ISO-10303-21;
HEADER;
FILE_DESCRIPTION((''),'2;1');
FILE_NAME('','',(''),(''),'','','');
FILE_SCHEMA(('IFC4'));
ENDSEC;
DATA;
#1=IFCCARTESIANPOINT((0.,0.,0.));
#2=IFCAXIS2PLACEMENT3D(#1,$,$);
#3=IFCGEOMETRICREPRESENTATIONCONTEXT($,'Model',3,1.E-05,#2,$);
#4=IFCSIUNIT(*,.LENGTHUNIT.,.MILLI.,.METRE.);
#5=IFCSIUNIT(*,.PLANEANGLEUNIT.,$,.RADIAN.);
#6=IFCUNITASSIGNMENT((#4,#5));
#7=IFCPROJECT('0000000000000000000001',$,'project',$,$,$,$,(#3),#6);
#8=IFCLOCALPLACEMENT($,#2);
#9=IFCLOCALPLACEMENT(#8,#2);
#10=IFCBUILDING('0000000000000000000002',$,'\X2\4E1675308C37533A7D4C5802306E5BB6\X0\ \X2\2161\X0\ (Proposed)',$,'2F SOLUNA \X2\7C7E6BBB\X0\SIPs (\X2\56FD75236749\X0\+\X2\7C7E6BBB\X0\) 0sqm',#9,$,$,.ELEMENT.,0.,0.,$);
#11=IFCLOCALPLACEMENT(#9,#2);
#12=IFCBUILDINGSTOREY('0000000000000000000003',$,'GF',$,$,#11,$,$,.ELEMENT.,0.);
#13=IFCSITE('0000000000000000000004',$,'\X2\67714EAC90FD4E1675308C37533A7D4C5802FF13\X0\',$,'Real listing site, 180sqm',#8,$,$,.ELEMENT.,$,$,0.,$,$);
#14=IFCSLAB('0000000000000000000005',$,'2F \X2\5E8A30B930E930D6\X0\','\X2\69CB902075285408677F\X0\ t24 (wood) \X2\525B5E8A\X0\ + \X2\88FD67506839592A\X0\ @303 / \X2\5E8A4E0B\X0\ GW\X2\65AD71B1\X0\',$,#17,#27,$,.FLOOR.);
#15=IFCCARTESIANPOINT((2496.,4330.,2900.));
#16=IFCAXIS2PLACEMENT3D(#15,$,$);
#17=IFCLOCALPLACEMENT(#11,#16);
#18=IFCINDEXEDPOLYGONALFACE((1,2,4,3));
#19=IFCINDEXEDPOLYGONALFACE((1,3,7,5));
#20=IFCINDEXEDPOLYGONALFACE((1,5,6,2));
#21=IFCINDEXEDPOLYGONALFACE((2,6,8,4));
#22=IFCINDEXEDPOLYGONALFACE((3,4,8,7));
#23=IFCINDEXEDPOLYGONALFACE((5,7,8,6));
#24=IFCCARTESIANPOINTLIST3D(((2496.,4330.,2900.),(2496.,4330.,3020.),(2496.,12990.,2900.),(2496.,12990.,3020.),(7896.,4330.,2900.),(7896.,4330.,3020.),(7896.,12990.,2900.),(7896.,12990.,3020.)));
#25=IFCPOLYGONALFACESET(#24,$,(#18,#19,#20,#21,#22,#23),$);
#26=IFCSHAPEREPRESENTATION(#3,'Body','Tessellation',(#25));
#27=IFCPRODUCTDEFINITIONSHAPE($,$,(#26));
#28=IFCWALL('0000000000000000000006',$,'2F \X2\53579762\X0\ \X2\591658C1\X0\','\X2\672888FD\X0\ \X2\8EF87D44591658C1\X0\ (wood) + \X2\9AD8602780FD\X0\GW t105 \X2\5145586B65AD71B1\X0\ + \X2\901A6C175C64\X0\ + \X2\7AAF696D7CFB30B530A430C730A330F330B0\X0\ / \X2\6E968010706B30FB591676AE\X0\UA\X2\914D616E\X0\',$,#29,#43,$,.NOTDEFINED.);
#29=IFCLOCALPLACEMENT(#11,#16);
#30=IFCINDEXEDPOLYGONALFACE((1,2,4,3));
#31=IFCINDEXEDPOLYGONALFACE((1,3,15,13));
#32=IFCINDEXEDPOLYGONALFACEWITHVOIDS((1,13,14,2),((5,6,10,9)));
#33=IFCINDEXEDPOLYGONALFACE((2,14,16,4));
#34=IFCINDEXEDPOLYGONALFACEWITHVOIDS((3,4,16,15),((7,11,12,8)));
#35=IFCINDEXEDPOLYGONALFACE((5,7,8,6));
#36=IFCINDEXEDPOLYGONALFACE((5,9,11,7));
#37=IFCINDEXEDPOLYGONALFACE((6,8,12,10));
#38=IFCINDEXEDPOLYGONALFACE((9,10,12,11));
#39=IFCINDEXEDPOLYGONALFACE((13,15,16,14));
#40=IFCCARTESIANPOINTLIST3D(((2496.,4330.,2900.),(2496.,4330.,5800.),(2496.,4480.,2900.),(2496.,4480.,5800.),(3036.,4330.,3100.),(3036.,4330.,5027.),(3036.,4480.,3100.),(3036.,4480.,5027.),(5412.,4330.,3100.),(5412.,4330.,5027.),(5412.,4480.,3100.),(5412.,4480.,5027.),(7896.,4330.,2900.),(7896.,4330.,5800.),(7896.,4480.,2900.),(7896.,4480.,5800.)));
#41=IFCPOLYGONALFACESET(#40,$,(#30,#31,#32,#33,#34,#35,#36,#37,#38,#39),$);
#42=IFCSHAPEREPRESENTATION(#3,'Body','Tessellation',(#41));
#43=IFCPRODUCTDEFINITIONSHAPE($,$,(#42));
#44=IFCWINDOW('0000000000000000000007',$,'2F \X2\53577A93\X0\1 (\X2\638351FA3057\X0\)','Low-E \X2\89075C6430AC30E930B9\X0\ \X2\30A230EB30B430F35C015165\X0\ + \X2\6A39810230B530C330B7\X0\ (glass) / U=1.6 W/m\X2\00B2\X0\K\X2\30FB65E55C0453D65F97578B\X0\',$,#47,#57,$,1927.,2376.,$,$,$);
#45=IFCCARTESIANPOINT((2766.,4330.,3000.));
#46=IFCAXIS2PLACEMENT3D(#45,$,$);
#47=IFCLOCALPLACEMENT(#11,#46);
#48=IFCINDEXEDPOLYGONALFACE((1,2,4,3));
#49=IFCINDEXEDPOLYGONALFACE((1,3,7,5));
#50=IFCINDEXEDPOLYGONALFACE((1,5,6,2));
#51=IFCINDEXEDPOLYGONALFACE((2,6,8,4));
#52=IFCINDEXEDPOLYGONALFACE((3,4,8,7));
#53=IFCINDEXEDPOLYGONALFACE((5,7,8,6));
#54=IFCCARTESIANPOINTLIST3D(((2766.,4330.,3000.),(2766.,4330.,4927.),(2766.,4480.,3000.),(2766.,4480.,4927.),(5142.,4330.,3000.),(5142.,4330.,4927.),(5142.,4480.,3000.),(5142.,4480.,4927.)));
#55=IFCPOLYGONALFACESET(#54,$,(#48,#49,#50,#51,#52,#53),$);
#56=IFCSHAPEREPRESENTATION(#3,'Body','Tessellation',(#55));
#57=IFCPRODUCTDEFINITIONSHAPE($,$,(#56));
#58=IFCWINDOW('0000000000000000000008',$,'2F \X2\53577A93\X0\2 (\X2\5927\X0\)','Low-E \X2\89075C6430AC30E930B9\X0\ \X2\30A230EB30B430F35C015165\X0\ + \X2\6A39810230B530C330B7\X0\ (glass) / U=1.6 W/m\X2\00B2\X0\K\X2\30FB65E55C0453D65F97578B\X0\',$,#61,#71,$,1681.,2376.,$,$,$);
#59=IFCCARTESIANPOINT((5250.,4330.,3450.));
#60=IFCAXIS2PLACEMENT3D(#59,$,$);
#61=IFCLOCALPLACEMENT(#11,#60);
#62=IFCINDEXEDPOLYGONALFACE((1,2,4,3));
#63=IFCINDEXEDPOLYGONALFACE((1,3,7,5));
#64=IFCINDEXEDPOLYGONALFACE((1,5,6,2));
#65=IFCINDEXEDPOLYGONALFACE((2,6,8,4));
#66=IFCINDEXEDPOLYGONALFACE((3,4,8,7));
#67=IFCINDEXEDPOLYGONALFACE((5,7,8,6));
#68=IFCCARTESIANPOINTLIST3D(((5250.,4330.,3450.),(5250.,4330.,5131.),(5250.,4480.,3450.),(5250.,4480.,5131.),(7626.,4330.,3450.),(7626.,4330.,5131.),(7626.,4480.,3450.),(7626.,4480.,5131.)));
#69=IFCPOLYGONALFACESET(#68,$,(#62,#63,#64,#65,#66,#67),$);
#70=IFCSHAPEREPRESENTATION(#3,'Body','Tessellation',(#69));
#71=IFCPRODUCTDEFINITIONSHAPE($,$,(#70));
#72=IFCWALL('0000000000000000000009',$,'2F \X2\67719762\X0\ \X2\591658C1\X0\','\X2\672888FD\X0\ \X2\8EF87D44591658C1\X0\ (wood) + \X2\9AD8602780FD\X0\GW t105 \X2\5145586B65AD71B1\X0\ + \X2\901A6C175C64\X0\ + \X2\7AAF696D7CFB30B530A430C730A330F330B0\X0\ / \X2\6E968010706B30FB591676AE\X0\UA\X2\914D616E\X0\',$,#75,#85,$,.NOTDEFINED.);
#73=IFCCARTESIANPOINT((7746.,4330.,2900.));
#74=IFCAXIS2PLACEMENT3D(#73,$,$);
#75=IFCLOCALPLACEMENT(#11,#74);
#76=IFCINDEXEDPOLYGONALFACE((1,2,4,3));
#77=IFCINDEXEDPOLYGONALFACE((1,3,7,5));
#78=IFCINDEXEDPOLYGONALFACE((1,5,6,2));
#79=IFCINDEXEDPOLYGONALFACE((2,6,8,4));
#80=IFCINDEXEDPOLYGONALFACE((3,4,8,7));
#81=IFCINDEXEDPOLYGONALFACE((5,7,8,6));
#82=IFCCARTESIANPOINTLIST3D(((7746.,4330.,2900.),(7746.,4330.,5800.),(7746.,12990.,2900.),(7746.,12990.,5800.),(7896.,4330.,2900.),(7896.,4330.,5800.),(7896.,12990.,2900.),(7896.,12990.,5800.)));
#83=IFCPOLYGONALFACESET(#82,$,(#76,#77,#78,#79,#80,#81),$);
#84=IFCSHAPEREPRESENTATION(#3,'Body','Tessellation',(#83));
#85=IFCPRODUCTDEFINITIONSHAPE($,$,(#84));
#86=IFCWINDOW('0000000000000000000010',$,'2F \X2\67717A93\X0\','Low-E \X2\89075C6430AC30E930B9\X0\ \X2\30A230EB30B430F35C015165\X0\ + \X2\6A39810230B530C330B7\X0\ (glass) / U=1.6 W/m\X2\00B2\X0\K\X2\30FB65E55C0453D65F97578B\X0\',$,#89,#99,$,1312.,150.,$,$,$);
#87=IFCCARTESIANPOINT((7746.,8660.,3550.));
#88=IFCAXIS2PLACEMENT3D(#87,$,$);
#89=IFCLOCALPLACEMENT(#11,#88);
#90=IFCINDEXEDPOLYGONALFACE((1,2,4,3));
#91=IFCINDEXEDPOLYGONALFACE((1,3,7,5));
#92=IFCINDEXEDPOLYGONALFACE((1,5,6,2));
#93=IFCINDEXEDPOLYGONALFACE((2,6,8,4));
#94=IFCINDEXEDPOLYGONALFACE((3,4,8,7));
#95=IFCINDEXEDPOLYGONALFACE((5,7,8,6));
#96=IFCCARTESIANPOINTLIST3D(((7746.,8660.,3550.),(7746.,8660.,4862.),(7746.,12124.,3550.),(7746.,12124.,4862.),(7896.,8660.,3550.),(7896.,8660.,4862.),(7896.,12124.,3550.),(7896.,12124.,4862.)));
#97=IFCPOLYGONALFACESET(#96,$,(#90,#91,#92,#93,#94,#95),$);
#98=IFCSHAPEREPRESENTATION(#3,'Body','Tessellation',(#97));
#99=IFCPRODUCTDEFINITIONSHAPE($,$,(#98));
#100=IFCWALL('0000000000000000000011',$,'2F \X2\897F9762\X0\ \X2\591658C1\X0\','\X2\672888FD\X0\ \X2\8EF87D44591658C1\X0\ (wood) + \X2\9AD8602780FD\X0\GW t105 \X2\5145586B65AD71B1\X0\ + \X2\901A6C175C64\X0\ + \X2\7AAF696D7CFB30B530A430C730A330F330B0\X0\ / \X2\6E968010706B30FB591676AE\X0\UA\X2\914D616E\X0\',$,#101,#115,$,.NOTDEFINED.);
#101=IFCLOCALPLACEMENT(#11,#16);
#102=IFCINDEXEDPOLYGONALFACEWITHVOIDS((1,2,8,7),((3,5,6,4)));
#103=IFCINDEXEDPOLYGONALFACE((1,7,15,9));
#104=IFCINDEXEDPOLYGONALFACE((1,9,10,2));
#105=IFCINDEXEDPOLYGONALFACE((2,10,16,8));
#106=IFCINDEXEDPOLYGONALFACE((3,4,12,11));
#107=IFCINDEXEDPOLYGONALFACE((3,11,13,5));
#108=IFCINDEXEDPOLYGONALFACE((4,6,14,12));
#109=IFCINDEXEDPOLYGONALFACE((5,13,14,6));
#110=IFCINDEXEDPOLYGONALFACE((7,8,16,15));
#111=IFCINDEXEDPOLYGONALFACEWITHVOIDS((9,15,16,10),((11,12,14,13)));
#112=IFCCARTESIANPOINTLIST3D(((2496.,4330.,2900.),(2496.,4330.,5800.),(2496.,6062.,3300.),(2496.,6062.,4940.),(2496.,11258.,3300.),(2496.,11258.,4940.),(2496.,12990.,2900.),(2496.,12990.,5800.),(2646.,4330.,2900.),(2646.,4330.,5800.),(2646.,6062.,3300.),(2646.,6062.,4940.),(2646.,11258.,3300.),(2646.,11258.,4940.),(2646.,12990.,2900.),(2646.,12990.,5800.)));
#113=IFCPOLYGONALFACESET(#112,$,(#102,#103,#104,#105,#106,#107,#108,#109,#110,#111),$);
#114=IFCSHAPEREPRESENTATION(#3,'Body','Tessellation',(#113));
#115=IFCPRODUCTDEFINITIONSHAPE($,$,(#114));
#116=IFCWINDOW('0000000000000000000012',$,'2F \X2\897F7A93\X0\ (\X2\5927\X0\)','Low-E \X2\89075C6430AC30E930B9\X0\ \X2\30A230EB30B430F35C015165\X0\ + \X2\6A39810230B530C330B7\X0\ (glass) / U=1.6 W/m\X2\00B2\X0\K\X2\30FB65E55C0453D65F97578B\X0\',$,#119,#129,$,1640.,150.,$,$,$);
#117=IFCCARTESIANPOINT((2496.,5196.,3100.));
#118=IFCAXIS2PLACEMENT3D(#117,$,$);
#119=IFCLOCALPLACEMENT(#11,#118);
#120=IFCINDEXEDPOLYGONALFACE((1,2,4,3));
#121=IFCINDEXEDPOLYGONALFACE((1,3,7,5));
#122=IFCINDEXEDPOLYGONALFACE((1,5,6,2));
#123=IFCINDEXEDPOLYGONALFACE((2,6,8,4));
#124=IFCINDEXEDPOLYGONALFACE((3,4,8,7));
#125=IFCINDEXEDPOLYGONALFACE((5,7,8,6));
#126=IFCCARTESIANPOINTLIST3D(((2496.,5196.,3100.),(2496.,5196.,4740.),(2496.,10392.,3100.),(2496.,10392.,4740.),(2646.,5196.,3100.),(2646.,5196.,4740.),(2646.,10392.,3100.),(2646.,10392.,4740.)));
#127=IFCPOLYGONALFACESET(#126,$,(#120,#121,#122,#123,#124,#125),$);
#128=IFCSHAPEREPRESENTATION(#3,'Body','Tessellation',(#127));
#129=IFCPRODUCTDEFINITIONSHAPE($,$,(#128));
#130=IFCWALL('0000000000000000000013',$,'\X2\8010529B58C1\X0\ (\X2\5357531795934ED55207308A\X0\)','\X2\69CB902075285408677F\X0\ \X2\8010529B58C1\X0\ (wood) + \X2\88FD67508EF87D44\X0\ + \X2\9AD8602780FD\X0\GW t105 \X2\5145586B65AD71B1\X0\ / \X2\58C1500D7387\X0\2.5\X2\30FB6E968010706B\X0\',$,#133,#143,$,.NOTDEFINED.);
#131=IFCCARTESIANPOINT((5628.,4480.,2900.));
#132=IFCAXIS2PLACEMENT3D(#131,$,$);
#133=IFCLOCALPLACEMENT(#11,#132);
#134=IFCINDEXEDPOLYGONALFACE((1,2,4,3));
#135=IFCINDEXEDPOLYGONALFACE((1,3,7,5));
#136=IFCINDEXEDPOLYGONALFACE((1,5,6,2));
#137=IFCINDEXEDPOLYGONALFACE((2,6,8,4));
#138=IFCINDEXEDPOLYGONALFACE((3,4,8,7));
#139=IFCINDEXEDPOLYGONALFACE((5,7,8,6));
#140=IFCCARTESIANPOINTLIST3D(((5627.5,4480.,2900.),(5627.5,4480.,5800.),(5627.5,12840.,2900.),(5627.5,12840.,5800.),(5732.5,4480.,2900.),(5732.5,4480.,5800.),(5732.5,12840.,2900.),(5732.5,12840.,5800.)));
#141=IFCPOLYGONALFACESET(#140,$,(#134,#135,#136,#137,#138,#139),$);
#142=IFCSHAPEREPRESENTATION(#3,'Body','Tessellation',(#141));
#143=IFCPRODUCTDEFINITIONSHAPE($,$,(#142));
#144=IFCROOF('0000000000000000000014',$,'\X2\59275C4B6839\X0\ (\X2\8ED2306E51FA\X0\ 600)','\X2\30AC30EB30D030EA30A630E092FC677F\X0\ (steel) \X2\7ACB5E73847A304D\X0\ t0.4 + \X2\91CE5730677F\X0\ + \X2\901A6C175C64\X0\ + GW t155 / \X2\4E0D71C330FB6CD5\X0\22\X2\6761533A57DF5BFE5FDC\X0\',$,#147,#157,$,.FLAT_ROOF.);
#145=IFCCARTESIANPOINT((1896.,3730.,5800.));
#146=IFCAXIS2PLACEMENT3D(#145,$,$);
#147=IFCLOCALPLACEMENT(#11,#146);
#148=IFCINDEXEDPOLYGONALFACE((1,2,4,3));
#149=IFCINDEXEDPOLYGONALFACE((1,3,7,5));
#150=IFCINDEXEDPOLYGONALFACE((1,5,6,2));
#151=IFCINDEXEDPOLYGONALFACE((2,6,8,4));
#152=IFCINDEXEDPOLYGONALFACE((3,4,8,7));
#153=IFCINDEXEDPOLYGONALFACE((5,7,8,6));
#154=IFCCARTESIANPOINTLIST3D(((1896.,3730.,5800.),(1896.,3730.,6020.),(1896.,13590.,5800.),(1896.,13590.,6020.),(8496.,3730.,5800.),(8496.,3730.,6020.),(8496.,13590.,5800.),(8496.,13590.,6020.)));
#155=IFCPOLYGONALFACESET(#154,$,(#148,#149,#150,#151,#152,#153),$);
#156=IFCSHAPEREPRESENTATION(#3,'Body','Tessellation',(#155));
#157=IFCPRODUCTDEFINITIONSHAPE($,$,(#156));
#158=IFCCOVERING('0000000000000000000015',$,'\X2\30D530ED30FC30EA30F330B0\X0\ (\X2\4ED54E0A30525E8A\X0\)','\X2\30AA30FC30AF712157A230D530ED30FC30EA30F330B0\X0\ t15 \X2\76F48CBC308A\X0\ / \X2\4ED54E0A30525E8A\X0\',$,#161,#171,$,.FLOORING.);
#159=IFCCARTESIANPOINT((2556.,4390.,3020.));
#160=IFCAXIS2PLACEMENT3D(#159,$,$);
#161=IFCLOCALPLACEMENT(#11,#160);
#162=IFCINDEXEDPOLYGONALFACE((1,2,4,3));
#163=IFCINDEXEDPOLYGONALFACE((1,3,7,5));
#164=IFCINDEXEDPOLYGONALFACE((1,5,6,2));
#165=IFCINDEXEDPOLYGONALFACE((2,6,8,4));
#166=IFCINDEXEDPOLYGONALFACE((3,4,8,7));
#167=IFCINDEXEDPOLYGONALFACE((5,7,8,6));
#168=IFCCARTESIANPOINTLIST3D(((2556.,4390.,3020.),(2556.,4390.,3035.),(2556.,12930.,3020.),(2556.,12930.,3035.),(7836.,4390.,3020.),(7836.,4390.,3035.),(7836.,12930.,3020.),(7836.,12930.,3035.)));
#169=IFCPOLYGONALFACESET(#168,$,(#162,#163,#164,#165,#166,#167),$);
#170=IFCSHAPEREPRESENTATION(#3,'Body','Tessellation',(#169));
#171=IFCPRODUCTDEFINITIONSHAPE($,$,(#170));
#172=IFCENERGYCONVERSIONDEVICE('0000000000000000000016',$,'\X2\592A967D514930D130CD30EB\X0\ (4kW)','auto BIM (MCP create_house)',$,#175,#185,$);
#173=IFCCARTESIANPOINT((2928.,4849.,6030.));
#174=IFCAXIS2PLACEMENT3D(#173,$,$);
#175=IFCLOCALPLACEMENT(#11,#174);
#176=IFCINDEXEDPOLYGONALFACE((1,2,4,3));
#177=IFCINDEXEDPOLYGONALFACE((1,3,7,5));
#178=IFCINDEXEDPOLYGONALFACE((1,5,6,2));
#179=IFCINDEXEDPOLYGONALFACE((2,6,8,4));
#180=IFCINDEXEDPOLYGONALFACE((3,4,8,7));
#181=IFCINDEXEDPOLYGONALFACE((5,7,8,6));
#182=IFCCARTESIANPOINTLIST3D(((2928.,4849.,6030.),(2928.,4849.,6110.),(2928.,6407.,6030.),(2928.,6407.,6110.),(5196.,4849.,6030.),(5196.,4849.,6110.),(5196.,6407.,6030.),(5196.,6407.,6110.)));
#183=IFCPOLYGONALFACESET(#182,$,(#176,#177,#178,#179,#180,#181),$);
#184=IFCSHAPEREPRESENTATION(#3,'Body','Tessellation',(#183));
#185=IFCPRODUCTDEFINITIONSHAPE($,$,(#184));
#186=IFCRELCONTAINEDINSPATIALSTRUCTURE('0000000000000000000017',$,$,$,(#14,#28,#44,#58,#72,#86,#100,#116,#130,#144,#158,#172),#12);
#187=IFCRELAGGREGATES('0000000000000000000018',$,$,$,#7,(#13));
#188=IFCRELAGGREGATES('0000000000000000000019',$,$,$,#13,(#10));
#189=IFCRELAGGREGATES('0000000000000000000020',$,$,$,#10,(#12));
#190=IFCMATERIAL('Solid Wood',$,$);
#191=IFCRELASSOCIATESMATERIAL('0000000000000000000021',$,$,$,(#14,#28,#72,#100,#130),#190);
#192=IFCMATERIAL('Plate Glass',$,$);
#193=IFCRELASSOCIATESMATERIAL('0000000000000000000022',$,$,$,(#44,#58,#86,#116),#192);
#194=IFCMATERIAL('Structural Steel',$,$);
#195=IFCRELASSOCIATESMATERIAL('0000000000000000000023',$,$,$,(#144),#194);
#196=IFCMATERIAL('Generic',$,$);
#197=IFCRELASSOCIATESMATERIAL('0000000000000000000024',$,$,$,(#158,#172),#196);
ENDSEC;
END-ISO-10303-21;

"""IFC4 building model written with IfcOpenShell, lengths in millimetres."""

from ifc_helpers import new_model, si_unit, frame, frame_2d, origin, place, context, project, spatial, rectangle, extrude, material, element, fill, save


model = new_model("IFC4")

# Units and contexts
model_context = context("Model", 3, precision=1e-05, world=origin())
ifc_project = project(units=[si_unit("LENGTHUNIT", "METRE", prefix="MILLI"), si_unit("PLANEANGLEUNIT", "RADIAN")], contexts=[model_context])

# Site, building, storey
site_placement = place(None, origin())
site = spatial("IfcSite", under=ifc_project, at=site_placement, Name="東京都世田谷区経堂３", ObjectType="Real listing site, 180sqm", CompositionType="ELEMENT", RefElevation=0.0)
building_placement = place(site_placement, origin())
building = spatial("IfcBuilding", under=site, at=building_placement, Name="世田谷区経堂の家 Ⅱ (Proposed)", ObjectType="2F SOLUNA 籾殻SIPs (国産杉+籾殻) 0sqm", CompositionType="ELEMENT", ElevationOfRefHeight=0.0, ElevationOfTerrain=0.0)
storey_placement = place(building_placement, origin())
storey = spatial("IfcBuildingStorey", under=building, at=storey_placement, Name="GF", CompositionType="ELEMENT", Elevation=0.0)

# Slab
ifc_material_1 = material(Name="Solid Wood")
slab_placement = place(storey_placement, frame((2496.0, 4330.0, 2900.0)))
element("IfcSlab", 1, at=slab_placement, inside=storey, material=ifc_material_1, Name="2F 床スラブ", Description="構造用合板 t24 (wood) 剛床 + 製材根太 @303 / 床下 GW断熱", PredefinedType="FLOOR", context=model_context, shape_type="SweptSolid", body=[
    extrude(rectangle(XDim=5400.0, YDim=8660.0, at=frame_2d((2700.0, 4330.0))), frame((2496.0, 4330.0, 2900.0)), (0.0, 0.0, 1.0), 120.0),
])

# Wall, openings, windows
wall_1_placement = place(storey_placement, frame((2496.0, 4330.0, 2900.0)))
wall_1 = element("IfcWall", 2, at=wall_1_placement, inside=storey, material=ifc_material_1, Name="2F 南面 外壁", Description="木製 軸組外壁 (wood) + 高性能GW t105 充填断熱 + 通気層 + 窯業系サイディング / 準耐火・外皮UA配慮", PredefinedType="NOTDEFINED", context=model_context, shape_type="SweptSolid", body=[
    extrude(rectangle(XDim=5400.0, YDim=150.0, at=frame_2d((2700.0, 75.0))), frame((2496.0, 4330.0, 2900.0)), (0.0, 0.0, 1.0), 2900.0),
])
opening_1_placement = place(storey_placement, frame((2766.0, 4330.0, 3000.0)))
opening_1 = element("IfcOpeningElement", 3, at=opening_1_placement, cuts=wall_1, PredefinedType="NOTDEFINED", context=model_context, shape_type="SweptSolid", body=[
    extrude(rectangle(XDim=2376.0, YDim=150.0, at=frame_2d((1188.0, 75.0))), frame((2766.0, 4330.0, 3000.0)), (0.0, 0.0, 1.0), 1927.0),
])
opening_2_placement = place(storey_placement, frame((5250.0, 4330.0, 3450.0)))
opening_2 = element("IfcOpeningElement", 4, at=opening_2_placement, cuts=wall_1, PredefinedType="NOTDEFINED", context=model_context, shape_type="SweptSolid", body=[
    extrude(rectangle(XDim=2376.0, YDim=150.0, at=frame_2d((1188.0, 75.0))), frame((5250.0, 4330.0, 3450.0)), (0.0, 0.0, 1.0), 1681.0),
])
ifc_material_2 = material(Name="Plate Glass")
window_1_placement = place(storey_placement, frame((2766.0, 4330.0, 3000.0)))
window_1 = element("IfcWindow", 5, at=window_1_placement, inside=storey, material=ifc_material_2, Name="2F 南窓1 (掃出し)", Description="Low-E 複層ガラス アルゴン封入 + 樹脂サッシ (glass) / U=1.6 W/m²K・日射取得型", OverallHeight=1927.0, OverallWidth=2376.0, context=model_context, shape_type="SweptSolid", body=[
    extrude(rectangle(XDim=2376.0, YDim=150.0, at=frame_2d((1188.0, 75.0))), frame((2766.0, 4330.0, 3000.0)), (0.0, 0.0, 1.0), 1927.0),
])
fill(opening_1, window_1)
window_2_placement = place(storey_placement, frame((5250.0, 4330.0, 3450.0)))
window_2 = element("IfcWindow", 6, at=window_2_placement, inside=storey, material=ifc_material_2, Name="2F 南窓2 (大)", Description="Low-E 複層ガラス アルゴン封入 + 樹脂サッシ (glass) / U=1.6 W/m²K・日射取得型", OverallHeight=1681.0, OverallWidth=2376.0, context=model_context, shape_type="SweptSolid", body=[
    extrude(rectangle(XDim=2376.0, YDim=150.0, at=frame_2d((1188.0, 75.0))), frame((5250.0, 4330.0, 3450.0)), (0.0, 0.0, 1.0), 1681.0),
])
fill(opening_2, window_2)

# Walls, openings, windows
wall_2_placement = place(storey_placement, frame((7746.0, 4330.0, 2900.0)))
wall_2 = element("IfcWall", 7, at=wall_2_placement, inside=storey, material=ifc_material_1, Name="2F 東面 外壁", Description="木製 軸組外壁 (wood) + 高性能GW t105 充填断熱 + 通気層 + 窯業系サイディング / 準耐火・外皮UA配慮", PredefinedType="NOTDEFINED", context=model_context, shape_type="SweptSolid", body=[
    extrude(rectangle(XDim=150.0, YDim=8660.0, at=frame_2d((75.0, 4330.0))), frame((7746.0, 4330.0, 2900.0)), (0.0, 0.0, 1.0), 2900.0),
])
opening_3_placement = place(storey_placement, frame((7746.0, 8660.0, 3550.0)))
opening_3 = element("IfcOpeningElement", 8, at=opening_3_placement, cuts=wall_2, PredefinedType="NOTDEFINED", context=model_context, shape_type="SweptSolid", body=[
    extrude(rectangle(XDim=150.0, YDim=3464.0, at=frame_2d((75.0, 1732.0))), frame((7746.0, 8660.0, 3550.0)), (0.0, 0.0, 1.0), 1312.0),
])
window_3_placement = place(storey_placement, frame((7746.0, 8660.0, 3550.0)))
window_3 = element("IfcWindow", 9, at=window_3_placement, inside=storey, material=ifc_material_2, Name="2F 東窓", Description="Low-E 複層ガラス アルゴン封入 + 樹脂サッシ (glass) / U=1.6 W/m²K・日射取得型", OverallHeight=1312.0, OverallWidth=150.0, context=model_context, shape_type="SweptSolid", body=[
    extrude(rectangle(XDim=150.0, YDim=3464.0, at=frame_2d((75.0, 1732.0))), frame((7746.0, 8660.0, 3550.0)), (0.0, 0.0, 1.0), 1312.0),
])
fill(opening_3, window_3)
wall_3_placement = place(storey_placement, frame((2496.0, 4330.0, 2900.0)))
wall_3 = element("IfcWall", 10, at=wall_3_placement, inside=storey, material=ifc_material_1, Name="2F 西面 外壁", Description="木製 軸組外壁 (wood) + 高性能GW t105 充填断熱 + 通気層 + 窯業系サイディング / 準耐火・外皮UA配慮", PredefinedType="NOTDEFINED", context=model_context, shape_type="SweptSolid", body=[
    extrude(rectangle(XDim=150.0, YDim=8660.0, at=frame_2d((75.0, 4330.0))), frame((2496.0, 4330.0, 2900.0)), (0.0, 0.0, 1.0), 2900.0),
])
opening_4_placement = place(storey_placement, frame((2496.0, 5196.0, 3100.0)))
opening_4 = element("IfcOpeningElement", 11, at=opening_4_placement, cuts=wall_3, PredefinedType="NOTDEFINED", context=model_context, shape_type="SweptSolid", body=[
    extrude(rectangle(XDim=150.0, YDim=5196.0, at=frame_2d((75.0, 2598.0))), frame((2496.0, 5196.0, 3100.0)), (0.0, 0.0, 1.0), 1640.0),
])
window_4_placement = place(storey_placement, frame((2496.0, 5196.0, 3100.0)))
window_4 = element("IfcWindow", 12, at=window_4_placement, inside=storey, material=ifc_material_2, Name="2F 西窓 (大)", Description="Low-E 複層ガラス アルゴン封入 + 樹脂サッシ (glass) / U=1.6 W/m²K・日射取得型", OverallHeight=1640.0, OverallWidth=150.0, context=model_context, shape_type="SweptSolid", body=[
    extrude(rectangle(XDim=150.0, YDim=5196.0, at=frame_2d((75.0, 2598.0))), frame((2496.0, 5196.0, 3100.0)), (0.0, 0.0, 1.0), 1640.0),
])
fill(opening_4, window_4)

# Wall
wall_4_placement = place(storey_placement, frame((5628.0, 4480.0, 2900.0)))
element("IfcWall", 13, at=wall_4_placement, inside=storey, material=ifc_material_1, Name="耐力壁 (南北間仕切り)", Description="構造用合板 耐力壁 (wood) + 製材軸組 + 高性能GW t105 充填断熱 / 壁倍率2.5・準耐火", PredefinedType="NOTDEFINED", context=model_context, shape_type="SweptSolid", body=[
    extrude(rectangle(XDim=105.0, YDim=8360.0, at=frame_2d((52.0, 4180.0))), frame((5628.0, 4480.0, 2900.0)), (0.0, 0.0, 1.0), 2900.0),
])

# Roof
ifc_material_3 = material(Name="Structural Steel")
roof_placement = place(storey_placement, frame((1896.0, 3730.0, 5800.0)))
element("IfcRoof", 14, at=roof_placement, inside=storey, material=ifc_material_3, Name="大屋根 (軒の出 600)", Description="ガルバリウム鋼板 (steel) 立平葺き t0.4 + 野地板 + 通気層 + GW t155 / 不燃・法22条区域対応", PredefinedType="FLAT_ROOF", context=model_context, shape_type="SweptSolid", body=[
    extrude(rectangle(XDim=6600.0, YDim=9860.0, at=frame_2d((3300.0, 4930.0))), frame((1896.0, 3730.0, 5800.0)), (0.0, 0.0, 1.0), 220.0),
])

# Covering
ifc_material_4 = material(Name="Generic")
covering_placement = place(storey_placement, frame((2556.0, 4390.0, 3020.0)))
element("IfcCovering", 15, at=covering_placement, inside=storey, material=ifc_material_4, Name="フローリング (仕上げ床)", Description="オーク無垢フローリング t15 直貼り / 仕上げ床", PredefinedType="FLOORING", context=model_context, shape_type="SweptSolid", body=[
    extrude(rectangle(XDim=5280.0, YDim=8540.0, at=frame_2d((2640.0, 4270.0))), frame((2556.0, 4390.0, 3020.0)), (0.0, 0.0, 1.0), 15.0),
])

# Energy conversion device
energy_conversion_device_placement = place(storey_placement, frame((2928.0, 4849.0, 6030.0)))
element("IfcEnergyConversionDevice", 16, at=energy_conversion_device_placement, inside=storey, material=ifc_material_4, Name="太陽光パネル (4kW)", Description="auto BIM (MCP create_house)", context=model_context, shape_type="SweptSolid", body=[
    extrude(rectangle(XDim=2268.0, YDim=1558.0, at=frame_2d((1134.0, 779.0))), frame((2928.0, 4849.0, 6030.0)), (0.0, 0.0, 1.0), 80.0),
])

save(model, "model.ifc")
